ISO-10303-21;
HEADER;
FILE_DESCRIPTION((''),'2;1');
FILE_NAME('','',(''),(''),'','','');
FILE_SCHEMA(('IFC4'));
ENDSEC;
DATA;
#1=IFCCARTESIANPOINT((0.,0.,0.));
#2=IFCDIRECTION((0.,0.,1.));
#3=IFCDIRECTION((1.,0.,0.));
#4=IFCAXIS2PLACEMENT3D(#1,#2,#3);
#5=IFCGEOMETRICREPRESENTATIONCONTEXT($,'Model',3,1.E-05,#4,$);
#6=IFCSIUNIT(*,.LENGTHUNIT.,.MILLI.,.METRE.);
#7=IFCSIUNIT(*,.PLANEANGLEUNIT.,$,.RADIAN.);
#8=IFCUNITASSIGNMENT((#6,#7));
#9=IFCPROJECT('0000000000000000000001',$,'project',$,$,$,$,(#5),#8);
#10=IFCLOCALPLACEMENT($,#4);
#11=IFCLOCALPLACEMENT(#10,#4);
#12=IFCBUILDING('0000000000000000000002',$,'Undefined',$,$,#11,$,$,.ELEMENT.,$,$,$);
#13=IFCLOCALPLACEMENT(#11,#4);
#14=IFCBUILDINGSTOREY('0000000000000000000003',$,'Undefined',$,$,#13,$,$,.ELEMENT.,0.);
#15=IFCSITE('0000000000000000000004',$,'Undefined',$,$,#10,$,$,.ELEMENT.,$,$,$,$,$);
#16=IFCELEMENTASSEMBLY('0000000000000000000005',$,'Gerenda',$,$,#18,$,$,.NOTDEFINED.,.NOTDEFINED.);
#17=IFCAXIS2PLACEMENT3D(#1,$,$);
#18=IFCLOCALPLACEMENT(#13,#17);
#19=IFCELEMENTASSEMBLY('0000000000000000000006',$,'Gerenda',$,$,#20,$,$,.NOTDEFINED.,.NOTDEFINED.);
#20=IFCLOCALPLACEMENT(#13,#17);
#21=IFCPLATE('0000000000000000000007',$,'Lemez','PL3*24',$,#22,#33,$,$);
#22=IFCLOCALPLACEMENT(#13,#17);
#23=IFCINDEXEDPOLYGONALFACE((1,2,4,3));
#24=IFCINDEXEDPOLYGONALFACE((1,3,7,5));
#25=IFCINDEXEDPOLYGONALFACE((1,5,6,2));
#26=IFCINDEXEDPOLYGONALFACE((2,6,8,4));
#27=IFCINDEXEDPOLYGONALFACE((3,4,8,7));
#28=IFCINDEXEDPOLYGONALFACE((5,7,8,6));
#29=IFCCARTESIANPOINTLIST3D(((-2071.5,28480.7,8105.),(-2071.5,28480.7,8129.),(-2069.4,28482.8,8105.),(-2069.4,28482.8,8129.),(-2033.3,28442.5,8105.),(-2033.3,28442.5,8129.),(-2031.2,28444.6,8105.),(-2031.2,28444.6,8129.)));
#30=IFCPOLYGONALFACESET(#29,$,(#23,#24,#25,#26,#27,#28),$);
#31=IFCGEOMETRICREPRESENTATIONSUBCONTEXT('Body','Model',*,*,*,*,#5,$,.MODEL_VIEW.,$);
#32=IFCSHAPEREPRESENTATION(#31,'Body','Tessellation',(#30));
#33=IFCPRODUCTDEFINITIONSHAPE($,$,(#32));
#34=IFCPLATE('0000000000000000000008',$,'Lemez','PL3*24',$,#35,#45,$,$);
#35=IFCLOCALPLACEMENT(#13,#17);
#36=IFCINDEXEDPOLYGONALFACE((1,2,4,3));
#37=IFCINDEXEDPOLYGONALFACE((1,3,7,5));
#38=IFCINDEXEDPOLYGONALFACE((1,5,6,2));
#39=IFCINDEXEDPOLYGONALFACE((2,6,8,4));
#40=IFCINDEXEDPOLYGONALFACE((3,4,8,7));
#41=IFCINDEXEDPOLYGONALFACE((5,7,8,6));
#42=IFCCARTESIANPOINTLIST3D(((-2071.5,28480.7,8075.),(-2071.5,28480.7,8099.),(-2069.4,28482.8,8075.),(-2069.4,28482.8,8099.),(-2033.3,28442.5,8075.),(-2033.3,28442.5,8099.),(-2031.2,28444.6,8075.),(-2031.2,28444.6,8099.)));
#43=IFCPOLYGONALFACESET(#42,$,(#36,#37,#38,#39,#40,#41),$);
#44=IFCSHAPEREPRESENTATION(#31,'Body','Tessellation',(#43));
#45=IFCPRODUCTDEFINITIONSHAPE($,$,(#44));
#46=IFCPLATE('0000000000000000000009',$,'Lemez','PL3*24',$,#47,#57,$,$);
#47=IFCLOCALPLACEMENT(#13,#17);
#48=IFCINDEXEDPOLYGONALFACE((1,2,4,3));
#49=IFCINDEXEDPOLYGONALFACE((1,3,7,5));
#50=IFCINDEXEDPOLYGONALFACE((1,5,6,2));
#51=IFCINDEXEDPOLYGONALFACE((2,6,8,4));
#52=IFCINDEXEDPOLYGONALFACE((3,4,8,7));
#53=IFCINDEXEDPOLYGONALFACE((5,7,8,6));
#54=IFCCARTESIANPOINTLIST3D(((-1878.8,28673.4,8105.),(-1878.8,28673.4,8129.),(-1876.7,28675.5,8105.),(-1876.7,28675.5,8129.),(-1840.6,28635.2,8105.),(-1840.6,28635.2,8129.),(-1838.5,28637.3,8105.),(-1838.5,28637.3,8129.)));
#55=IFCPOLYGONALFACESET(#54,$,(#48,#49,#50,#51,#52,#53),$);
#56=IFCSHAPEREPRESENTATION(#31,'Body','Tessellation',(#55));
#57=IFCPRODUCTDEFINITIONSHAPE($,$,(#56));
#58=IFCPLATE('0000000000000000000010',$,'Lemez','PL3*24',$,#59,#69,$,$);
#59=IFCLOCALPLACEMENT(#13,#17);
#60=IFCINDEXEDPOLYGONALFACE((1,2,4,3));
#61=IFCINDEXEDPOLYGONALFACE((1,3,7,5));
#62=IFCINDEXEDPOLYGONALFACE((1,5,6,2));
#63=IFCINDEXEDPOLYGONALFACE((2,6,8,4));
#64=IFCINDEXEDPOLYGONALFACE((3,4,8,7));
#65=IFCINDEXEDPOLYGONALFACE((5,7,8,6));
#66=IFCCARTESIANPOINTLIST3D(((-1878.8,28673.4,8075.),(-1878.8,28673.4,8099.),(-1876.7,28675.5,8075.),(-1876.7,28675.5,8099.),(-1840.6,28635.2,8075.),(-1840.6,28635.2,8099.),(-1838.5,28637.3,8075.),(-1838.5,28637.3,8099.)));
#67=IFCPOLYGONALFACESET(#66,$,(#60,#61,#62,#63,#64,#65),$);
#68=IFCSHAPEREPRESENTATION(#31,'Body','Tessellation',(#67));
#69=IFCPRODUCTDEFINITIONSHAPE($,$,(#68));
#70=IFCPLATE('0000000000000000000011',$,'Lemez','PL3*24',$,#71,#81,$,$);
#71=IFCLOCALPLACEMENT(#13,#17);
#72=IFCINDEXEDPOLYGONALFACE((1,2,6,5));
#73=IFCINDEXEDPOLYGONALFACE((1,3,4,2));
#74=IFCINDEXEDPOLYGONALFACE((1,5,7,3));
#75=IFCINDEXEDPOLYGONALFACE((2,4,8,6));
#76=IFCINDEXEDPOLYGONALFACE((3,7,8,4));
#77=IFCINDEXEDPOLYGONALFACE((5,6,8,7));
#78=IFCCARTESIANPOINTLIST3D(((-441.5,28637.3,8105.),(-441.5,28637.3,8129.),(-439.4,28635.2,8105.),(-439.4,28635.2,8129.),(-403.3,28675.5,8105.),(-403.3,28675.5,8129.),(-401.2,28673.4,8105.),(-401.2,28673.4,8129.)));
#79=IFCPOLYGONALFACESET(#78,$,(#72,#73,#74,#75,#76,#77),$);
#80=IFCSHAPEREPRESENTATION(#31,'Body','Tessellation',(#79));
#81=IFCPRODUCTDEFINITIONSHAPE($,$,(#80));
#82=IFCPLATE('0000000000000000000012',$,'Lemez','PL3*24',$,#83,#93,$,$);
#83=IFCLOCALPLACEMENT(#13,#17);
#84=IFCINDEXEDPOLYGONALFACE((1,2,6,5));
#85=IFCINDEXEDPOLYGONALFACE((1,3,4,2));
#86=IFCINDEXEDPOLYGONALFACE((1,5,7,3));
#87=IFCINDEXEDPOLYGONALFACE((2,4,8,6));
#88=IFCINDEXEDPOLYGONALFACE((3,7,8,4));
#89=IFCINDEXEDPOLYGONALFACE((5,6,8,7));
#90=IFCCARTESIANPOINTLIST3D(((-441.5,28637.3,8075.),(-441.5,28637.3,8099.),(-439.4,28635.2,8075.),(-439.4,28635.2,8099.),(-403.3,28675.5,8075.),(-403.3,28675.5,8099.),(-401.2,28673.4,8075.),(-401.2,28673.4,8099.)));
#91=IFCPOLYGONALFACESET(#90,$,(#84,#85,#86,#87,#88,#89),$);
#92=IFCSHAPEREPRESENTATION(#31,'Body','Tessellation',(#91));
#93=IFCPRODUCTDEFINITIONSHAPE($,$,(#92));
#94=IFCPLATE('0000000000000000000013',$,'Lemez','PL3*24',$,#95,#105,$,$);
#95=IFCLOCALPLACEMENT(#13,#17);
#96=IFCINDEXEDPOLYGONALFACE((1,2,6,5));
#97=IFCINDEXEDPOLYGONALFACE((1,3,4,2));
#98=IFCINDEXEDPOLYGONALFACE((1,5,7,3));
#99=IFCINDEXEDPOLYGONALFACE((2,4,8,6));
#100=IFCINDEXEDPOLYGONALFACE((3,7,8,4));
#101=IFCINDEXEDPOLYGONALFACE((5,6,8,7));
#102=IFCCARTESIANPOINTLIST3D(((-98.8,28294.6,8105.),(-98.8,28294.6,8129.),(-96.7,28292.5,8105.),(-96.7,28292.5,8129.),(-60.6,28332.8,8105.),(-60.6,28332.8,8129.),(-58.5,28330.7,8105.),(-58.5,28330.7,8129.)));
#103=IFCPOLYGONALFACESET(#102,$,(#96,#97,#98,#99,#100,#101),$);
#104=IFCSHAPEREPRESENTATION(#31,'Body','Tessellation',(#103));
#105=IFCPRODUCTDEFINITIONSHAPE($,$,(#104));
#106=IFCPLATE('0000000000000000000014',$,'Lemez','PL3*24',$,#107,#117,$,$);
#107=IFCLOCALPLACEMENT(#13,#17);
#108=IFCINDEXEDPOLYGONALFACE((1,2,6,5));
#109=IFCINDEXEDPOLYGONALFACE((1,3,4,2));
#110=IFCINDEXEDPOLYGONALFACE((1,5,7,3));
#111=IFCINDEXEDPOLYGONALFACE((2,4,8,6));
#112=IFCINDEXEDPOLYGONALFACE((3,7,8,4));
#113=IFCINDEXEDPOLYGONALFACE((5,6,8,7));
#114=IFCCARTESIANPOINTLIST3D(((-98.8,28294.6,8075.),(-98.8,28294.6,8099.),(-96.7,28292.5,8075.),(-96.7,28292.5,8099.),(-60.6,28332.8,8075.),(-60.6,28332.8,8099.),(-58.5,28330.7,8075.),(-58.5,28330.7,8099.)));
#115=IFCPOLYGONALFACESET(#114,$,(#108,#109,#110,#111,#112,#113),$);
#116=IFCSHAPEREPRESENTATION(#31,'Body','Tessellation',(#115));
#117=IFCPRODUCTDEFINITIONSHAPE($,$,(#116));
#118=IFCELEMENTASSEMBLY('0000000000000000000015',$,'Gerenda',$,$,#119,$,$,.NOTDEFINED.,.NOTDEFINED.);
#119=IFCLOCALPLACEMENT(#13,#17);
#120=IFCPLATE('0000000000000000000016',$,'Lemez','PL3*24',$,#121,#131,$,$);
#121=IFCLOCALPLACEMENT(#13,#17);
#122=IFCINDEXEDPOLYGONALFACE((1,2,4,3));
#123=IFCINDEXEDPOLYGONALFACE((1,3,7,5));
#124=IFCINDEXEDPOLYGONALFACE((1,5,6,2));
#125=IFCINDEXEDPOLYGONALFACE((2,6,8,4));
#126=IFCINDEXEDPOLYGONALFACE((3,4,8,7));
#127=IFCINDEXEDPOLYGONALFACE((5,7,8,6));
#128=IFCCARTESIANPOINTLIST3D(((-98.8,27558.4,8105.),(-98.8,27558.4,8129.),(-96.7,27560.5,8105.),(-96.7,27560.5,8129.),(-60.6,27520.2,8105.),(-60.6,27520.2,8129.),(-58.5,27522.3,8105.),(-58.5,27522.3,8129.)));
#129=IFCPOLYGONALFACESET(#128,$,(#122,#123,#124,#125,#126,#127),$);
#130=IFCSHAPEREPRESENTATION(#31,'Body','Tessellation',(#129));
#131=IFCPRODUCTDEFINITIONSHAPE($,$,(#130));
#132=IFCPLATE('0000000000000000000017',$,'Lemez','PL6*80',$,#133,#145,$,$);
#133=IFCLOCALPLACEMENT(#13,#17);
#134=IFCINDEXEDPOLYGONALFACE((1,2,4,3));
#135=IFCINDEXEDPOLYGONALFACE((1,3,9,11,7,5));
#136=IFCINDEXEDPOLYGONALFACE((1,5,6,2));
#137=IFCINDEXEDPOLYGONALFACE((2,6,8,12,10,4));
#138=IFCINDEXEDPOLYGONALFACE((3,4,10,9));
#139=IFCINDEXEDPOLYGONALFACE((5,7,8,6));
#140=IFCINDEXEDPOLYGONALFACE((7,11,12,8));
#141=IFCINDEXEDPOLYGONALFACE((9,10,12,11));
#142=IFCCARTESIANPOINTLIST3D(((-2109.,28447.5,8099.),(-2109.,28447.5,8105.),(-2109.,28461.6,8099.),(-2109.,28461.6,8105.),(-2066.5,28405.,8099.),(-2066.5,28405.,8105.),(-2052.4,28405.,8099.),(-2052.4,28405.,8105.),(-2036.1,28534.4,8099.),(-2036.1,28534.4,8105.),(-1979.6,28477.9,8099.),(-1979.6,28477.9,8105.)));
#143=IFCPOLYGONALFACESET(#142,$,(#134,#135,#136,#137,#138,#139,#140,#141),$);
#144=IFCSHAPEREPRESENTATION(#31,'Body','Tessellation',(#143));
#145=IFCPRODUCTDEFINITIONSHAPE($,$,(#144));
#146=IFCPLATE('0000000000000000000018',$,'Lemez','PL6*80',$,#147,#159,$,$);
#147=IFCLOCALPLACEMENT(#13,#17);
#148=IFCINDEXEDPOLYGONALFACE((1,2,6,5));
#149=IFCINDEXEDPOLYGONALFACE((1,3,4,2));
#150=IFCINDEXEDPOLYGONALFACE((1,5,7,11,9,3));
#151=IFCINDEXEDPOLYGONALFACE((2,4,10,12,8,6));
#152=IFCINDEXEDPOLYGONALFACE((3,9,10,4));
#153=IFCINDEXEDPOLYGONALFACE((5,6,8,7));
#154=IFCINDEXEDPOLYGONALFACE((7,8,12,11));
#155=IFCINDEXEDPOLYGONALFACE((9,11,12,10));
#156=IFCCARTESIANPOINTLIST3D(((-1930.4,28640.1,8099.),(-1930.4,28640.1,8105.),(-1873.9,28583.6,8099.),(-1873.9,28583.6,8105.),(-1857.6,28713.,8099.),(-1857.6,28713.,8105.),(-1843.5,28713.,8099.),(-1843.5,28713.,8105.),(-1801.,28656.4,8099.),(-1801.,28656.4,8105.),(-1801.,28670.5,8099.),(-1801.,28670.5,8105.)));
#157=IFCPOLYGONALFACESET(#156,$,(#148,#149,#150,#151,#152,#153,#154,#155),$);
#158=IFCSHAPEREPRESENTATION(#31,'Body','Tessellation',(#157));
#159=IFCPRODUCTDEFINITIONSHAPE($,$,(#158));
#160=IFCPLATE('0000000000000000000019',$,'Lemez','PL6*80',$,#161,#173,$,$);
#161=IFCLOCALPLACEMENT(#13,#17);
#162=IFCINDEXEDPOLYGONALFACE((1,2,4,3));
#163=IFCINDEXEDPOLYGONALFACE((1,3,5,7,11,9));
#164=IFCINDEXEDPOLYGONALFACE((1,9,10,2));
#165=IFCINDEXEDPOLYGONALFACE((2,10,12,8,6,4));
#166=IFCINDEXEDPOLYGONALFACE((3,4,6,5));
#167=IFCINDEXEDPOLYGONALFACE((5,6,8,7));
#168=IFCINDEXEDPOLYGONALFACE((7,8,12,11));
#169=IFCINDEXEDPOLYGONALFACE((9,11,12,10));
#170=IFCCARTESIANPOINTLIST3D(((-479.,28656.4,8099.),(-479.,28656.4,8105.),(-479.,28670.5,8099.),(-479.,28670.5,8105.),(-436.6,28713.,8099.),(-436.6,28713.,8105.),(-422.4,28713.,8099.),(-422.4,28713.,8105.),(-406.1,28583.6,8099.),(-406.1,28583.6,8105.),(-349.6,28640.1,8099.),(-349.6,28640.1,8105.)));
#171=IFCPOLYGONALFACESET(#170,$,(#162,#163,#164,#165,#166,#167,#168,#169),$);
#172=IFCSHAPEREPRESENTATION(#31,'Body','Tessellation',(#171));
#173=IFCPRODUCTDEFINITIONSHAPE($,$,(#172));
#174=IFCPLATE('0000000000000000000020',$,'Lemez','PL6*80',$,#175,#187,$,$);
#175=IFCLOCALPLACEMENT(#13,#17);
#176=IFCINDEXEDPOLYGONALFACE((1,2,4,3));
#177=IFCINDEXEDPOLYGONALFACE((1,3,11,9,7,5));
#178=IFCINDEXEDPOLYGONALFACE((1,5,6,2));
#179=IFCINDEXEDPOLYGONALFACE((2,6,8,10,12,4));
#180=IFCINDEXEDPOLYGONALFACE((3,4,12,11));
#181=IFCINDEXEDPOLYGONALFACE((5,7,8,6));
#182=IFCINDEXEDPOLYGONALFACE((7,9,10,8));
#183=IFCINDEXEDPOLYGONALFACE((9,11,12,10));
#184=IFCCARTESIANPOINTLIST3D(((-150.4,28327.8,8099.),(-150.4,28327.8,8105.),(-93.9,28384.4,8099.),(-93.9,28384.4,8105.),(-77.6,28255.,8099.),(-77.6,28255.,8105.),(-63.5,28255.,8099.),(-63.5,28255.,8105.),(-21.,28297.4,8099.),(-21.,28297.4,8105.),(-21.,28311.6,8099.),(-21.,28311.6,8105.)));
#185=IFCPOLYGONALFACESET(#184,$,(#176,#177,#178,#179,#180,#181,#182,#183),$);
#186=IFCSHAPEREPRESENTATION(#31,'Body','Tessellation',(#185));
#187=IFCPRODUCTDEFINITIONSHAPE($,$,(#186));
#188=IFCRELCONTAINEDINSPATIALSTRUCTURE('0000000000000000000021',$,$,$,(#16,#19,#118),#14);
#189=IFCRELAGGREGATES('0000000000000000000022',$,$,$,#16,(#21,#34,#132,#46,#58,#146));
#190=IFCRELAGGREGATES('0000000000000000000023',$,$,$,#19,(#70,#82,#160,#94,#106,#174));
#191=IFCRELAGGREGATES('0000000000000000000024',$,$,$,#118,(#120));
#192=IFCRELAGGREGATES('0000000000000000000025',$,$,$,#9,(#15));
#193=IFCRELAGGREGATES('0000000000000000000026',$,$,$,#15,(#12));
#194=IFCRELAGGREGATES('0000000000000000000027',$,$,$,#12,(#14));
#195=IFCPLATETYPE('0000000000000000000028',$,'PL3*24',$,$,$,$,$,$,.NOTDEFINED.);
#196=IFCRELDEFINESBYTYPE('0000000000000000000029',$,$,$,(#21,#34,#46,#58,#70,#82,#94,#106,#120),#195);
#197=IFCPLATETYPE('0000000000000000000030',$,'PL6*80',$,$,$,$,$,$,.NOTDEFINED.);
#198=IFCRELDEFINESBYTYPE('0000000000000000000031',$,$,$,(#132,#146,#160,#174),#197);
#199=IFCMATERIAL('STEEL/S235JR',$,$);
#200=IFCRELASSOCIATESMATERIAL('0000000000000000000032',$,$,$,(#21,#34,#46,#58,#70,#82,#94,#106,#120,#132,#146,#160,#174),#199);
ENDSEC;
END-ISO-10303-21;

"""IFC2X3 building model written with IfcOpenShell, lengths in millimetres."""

from ifc_helpers import new_model, si_unit, frame, origin_with_axes, place, context, subcontext, project, spatial, polyline, outline, extrude, material, type_object, element, aggregate, save


model = new_model("IFC2X3")

# Units and contexts
model_context = context("Model", 3, precision=1e-05, world=origin_with_axes())
body_context = subcontext(model_context, "Body", "Model", "MODEL_VIEW")
ifc_project = project(units=[si_unit("LENGTHUNIT", "METRE", prefix="MILLI"), si_unit("PLANEANGLEUNIT", "RADIAN")], contexts=[model_context])

# Site, building, storey
site_placement = place(None, origin_with_axes())
site = spatial("IfcSite", under=ifc_project, at=site_placement, Name="Undefined", CompositionType="ELEMENT")
building_placement = place(site_placement, origin_with_axes())
building = spatial("IfcBuilding", under=site, at=building_placement, Name="Undefined", CompositionType="ELEMENT")
storey_placement = place(building_placement, origin_with_axes())
storey = spatial("IfcBuildingStorey", under=building, at=storey_placement, Name="Undefined", CompositionType="ELEMENT", Elevation=0.0)

# Element assemblies
assembly_1_placement = place(storey_placement, origin_with_axes())
assembly_1 = element("IfcElementAssembly", 1, at=assembly_1_placement, inside=storey, Name="Gerenda", AssemblyPlace="NOTDEFINED", PredefinedType="NOTDEFINED")
ifc_material_1 = material(Name="STEEL/S235JR")
assembly_2_placement = place(storey_placement, origin_with_axes())
assembly_2 = element("IfcElementAssembly", 2, at=assembly_2_placement, inside=storey, Name="Gerenda", AssemblyPlace="NOTDEFINED", PredefinedType="NOTDEFINED")

# Plates
plate_type_1 = type_object("IfcPlateType", Name="PL3*24", PredefinedType="NOTDEFINED")
plate_1_placement = place(assembly_1_placement, frame((-2032.2, 28443.6, 8129.0), z_axis=(0.707112, 0.707102, 0.0), x_axis=(0.0, 0.0, -1.0)))
plate_1 = element("IfcPlate", 3, at=plate_1_placement, type_object=plate_type_1, material=ifc_material_1, Name="Lemez", Description="PL3*24", context=body_context, shape_type="SweptSolid", body=[
    extrude(outline(polyline([(0.0, 0.0), (24.0, 0.0), (24.0, 54.0), (0.0, 54.0), (0.0, 0.0)])), frame((0.0, 0.0, -1.5), z_axis=(0.0, 0.0, 1.0), x_axis=(1.0, 0.0, 0.0)), (0.0, 0.0, 1.0), 3.0),
])
plate_2_placement = place(assembly_1_placement, frame((-2032.2, 28443.6, 8099.0), z_axis=(0.707112, 0.707102, 0.0), x_axis=(0.0, 0.0, -1.0)))
plate_2 = element("IfcPlate", 4, at=plate_2_placement, type_object=plate_type_1, material=ifc_material_1, Name="Lemez", Description="PL3*24", context=body_context, shape_type="SweptSolid", body=[
    extrude(outline(polyline([(0.0, 0.0), (24.0, 0.0), (24.0, 54.0), (0.0, 54.0), (0.0, 0.0)])), frame((0.0, 0.0, -1.5), z_axis=(0.0, 0.0, 1.0), x_axis=(1.0, 0.0, 0.0)), (0.0, 0.0, 1.0), 3.0),
])
plate_3_placement = place(assembly_1_placement, frame((-1877.7, 28674.4, 8129.0), z_axis=(-0.707112, -0.707102, 0.0), x_axis=(0.0, 0.0, -1.0)))
plate_3 = element("IfcPlate", 5, at=plate_3_placement, type_object=plate_type_1, material=ifc_material_1, Name="Lemez", Description="PL3*24", context=body_context, shape_type="SweptSolid", body=[
    extrude(outline(polyline([(0.0, 0.0), (24.0, 0.0), (24.0, 54.0), (0.0, 54.0), (0.0, 0.0)])), frame((0.0, 0.0, -1.5), z_axis=(0.0, 0.0, 1.0), x_axis=(1.0, 0.0, 0.0)), (0.0, 0.0, 1.0), 3.0),
])
plate_4_placement = place(assembly_1_placement, frame((-1877.7, 28674.4, 8099.0), z_axis=(-0.707112, -0.707102, 0.0), x_axis=(0.0, 0.0, -1.0)))
plate_4 = element("IfcPlate", 6, at=plate_4_placement, type_object=plate_type_1, material=ifc_material_1, Name="Lemez", Description="PL3*24", context=body_context, shape_type="SweptSolid", body=[
    extrude(outline(polyline([(0.0, 0.0), (24.0, 0.0), (24.0, 54.0), (0.0, 54.0), (0.0, 0.0)])), frame((0.0, 0.0, -1.5), z_axis=(0.0, 0.0, 1.0), x_axis=(1.0, 0.0, 0.0)), (0.0, 0.0, 1.0), 3.0),
])
plate_5_placement = place(assembly_2_placement, frame((-440.4, 28636.2, 8129.0), z_axis=(0.707112, -0.707102, 0.0), x_axis=(0.0, 0.0, -1.0)))
plate_5 = element("IfcPlate", 7, at=plate_5_placement, type_object=plate_type_1, material=ifc_material_1, Name="Lemez", Description="PL3*24", context=body_context, shape_type="SweptSolid", body=[
    extrude(outline(polyline([(0.0, 0.0), (24.0, 0.0), (24.0, 54.0), (0.0, 54.0), (0.0, 0.0)])), frame((0.0, 0.0, -1.5), z_axis=(0.0, 0.0, 1.0), x_axis=(1.0, 0.0, 0.0)), (0.0, 0.0, 1.0), 3.0),
])
plate_6_placement = place(assembly_2_placement, frame((-440.4, 28636.2, 8099.0), z_axis=(0.707112, -0.707102, 0.0), x_axis=(0.0, 0.0, -1.0)))
plate_6 = element("IfcPlate", 8, at=plate_6_placement, type_object=plate_type_1, material=ifc_material_1, Name="Lemez", Description="PL3*24", context=body_context, shape_type="SweptSolid", body=[
    extrude(outline(polyline([(0.0, 0.0), (24.0, 0.0), (24.0, 54.0), (0.0, 54.0), (0.0, 0.0)])), frame((0.0, 0.0, -1.5), z_axis=(0.0, 0.0, 1.0), x_axis=(1.0, 0.0, 0.0)), (0.0, 0.0, 1.0), 3.0),
])
plate_7_placement = place(assembly_2_placement, frame((-59.6, 28331.7, 8129.0), z_axis=(-0.707112, 0.707102, 0.0), x_axis=(0.0, 0.0, -1.0)))
plate_7 = element("IfcPlate", 9, at=plate_7_placement, type_object=plate_type_1, material=ifc_material_1, Name="Lemez", Description="PL3*24", context=body_context, shape_type="SweptSolid", body=[
    extrude(outline(polyline([(0.0, 0.0), (24.0, 0.0), (24.0, 54.0), (0.0, 54.0), (0.0, 0.0)])), frame((0.0, 0.0, -1.5), z_axis=(0.0, 0.0, 1.0), x_axis=(1.0, 0.0, 0.0)), (0.0, 0.0, 1.0), 3.0),
])
plate_8_placement = place(assembly_2_placement, frame((-59.6, 28331.7, 8099.0), z_axis=(-0.707112, 0.707102, 0.0), x_axis=(0.0, 0.0, -1.0)))
plate_8 = element("IfcPlate", 10, at=plate_8_placement, type_object=plate_type_1, material=ifc_material_1, Name="Lemez", Description="PL3*24", context=body_context, shape_type="SweptSolid", body=[
    extrude(outline(polyline([(0.0, 0.0), (24.0, 0.0), (24.0, 54.0), (0.0, 54.0), (0.0, 0.0)])), frame((0.0, 0.0, -1.5), z_axis=(0.0, 0.0, 1.0), x_axis=(1.0, 0.0, 0.0)), (0.0, 0.0, 1.0), 3.0),
])

# Element assembly, plate
assembly_3_placement = place(storey_placement, origin_with_axes())
assembly_3 = element("IfcElementAssembly", 11, at=assembly_3_placement, inside=storey, Name="Gerenda", AssemblyPlace="NOTDEFINED", PredefinedType="NOTDEFINED")
plate_9_placement = place(assembly_3_placement, frame((-97.7, 27559.4, 8129.0), z_axis=(-0.707112, -0.707102, 0.0), x_axis=(0.0, 0.0, -1.0)))
plate_9 = element("IfcPlate", 12, at=plate_9_placement, type_object=plate_type_1, material=ifc_material_1, Name="Lemez", Description="PL3*24", context=body_context, shape_type="SweptSolid", body=[
    extrude(outline(polyline([(0.0, 0.0), (24.0, 0.0), (24.0, 54.0), (0.0, 54.0), (0.0, 0.0)])), frame((0.0, 0.0, -1.5), z_axis=(0.0, 0.0, 1.0), x_axis=(1.0, 0.0, 0.0)), (0.0, 0.0, 1.0), 3.0),
])

# Plates
plate_type_2 = type_object("IfcPlateType", Name="PL6*80", PredefinedType="NOTDEFINED")
plate_10_placement = place(assembly_1_placement, frame((-2109.0, 28461.6, 8102.0), z_axis=(0.0, 0.0, 1.0), x_axis=(-0.000007, -1.0, 0.0)))
plate_10 = element("IfcPlate", 13, at=plate_10_placement, type_object=plate_type_2, material=ifc_material_1, Name="Lemez", Description="PL6*80", context=body_context, shape_type="SweptSolid", body=[
    extrude(outline(polyline([(0.0, 0.0), (14.1, 0.0), (56.6, 42.4), (56.6, 56.6), (-16.3, 129.4), (-72.8, 72.8), (0.0, 0.0)])), frame((0.0, 0.0, -3.0), z_axis=(0.0, 0.0, 1.0), x_axis=(1.0, 0.0, 0.0)), (0.0, 0.0, 1.0), 6.0),
])
plate_11_placement = place(assembly_1_placement, frame((-1801.0, 28656.4, 8102.0), z_axis=(0.0, 0.0, 1.0), x_axis=(0.000007, 1.0, 0.0)))
plate_11 = element("IfcPlate", 14, at=plate_11_placement, type_object=plate_type_2, material=ifc_material_1, Name="Lemez", Description="PL6*80", context=body_context, shape_type="SweptSolid", body=[
    extrude(outline(polyline([(0.0, 0.0), (14.1, 0.0), (56.6, 42.4), (56.6, 56.6), (-16.3, 129.4), (-72.8, 72.8), (0.0, 0.0)])), frame((0.0, 0.0, -3.0), z_axis=(0.0, 0.0, 1.0), x_axis=(1.0, 0.0, 0.0)), (0.0, 0.0, 1.0), 6.0),
])
plate_12_placement = place(assembly_2_placement, frame((-422.4, 28713.0, 8102.0), z_axis=(0.0, 0.0, 1.0), x_axis=(-1.0, -0.000007, 0.0)))
plate_12 = element("IfcPlate", 15, at=plate_12_placement, type_object=plate_type_2, material=ifc_material_1, Name="Lemez", Description="PL6*80", context=body_context, shape_type="SweptSolid", body=[
    extrude(outline(polyline([(0.0, 0.0), (14.1, 0.0), (56.6, 42.4), (56.6, 56.6), (-16.3, 129.4), (-72.8, 72.8), (0.0, 0.0)])), frame((0.0, 0.0, -3.0), z_axis=(0.0, 0.0, 1.0), x_axis=(1.0, 0.0, 0.0)), (0.0, 0.0, 1.0), 6.0),
])
plate_13_placement = place(assembly_2_placement, frame((-77.6, 28255.0, 8102.0), z_axis=(0.0, 0.0, 1.0), x_axis=(1.0, 0.000007, 0.0)))
plate_13 = element("IfcPlate", 16, at=plate_13_placement, type_object=plate_type_2, material=ifc_material_1, Name="Lemez", Description="PL6*80", context=body_context, shape_type="SweptSolid", body=[
    extrude(outline(polyline([(0.0, 0.0), (14.1, 0.0), (56.6, 42.4), (56.6, 56.6), (-16.3, 129.4), (-72.8, 72.8), (0.0, 0.0)])), frame((0.0, 0.0, -3.0), z_axis=(0.0, 0.0, 1.0), x_axis=(1.0, 0.0, 0.0)), (0.0, 0.0, 1.0), 6.0),
])

aggregate(assembly_1, [plate_1, plate_2, plate_10, plate_3, plate_4, plate_11])
aggregate(assembly_2, [plate_5, plate_6, plate_12, plate_7, plate_8, plate_13])
aggregate(assembly_3, [plate_9])

save(model, "model.ifc")
